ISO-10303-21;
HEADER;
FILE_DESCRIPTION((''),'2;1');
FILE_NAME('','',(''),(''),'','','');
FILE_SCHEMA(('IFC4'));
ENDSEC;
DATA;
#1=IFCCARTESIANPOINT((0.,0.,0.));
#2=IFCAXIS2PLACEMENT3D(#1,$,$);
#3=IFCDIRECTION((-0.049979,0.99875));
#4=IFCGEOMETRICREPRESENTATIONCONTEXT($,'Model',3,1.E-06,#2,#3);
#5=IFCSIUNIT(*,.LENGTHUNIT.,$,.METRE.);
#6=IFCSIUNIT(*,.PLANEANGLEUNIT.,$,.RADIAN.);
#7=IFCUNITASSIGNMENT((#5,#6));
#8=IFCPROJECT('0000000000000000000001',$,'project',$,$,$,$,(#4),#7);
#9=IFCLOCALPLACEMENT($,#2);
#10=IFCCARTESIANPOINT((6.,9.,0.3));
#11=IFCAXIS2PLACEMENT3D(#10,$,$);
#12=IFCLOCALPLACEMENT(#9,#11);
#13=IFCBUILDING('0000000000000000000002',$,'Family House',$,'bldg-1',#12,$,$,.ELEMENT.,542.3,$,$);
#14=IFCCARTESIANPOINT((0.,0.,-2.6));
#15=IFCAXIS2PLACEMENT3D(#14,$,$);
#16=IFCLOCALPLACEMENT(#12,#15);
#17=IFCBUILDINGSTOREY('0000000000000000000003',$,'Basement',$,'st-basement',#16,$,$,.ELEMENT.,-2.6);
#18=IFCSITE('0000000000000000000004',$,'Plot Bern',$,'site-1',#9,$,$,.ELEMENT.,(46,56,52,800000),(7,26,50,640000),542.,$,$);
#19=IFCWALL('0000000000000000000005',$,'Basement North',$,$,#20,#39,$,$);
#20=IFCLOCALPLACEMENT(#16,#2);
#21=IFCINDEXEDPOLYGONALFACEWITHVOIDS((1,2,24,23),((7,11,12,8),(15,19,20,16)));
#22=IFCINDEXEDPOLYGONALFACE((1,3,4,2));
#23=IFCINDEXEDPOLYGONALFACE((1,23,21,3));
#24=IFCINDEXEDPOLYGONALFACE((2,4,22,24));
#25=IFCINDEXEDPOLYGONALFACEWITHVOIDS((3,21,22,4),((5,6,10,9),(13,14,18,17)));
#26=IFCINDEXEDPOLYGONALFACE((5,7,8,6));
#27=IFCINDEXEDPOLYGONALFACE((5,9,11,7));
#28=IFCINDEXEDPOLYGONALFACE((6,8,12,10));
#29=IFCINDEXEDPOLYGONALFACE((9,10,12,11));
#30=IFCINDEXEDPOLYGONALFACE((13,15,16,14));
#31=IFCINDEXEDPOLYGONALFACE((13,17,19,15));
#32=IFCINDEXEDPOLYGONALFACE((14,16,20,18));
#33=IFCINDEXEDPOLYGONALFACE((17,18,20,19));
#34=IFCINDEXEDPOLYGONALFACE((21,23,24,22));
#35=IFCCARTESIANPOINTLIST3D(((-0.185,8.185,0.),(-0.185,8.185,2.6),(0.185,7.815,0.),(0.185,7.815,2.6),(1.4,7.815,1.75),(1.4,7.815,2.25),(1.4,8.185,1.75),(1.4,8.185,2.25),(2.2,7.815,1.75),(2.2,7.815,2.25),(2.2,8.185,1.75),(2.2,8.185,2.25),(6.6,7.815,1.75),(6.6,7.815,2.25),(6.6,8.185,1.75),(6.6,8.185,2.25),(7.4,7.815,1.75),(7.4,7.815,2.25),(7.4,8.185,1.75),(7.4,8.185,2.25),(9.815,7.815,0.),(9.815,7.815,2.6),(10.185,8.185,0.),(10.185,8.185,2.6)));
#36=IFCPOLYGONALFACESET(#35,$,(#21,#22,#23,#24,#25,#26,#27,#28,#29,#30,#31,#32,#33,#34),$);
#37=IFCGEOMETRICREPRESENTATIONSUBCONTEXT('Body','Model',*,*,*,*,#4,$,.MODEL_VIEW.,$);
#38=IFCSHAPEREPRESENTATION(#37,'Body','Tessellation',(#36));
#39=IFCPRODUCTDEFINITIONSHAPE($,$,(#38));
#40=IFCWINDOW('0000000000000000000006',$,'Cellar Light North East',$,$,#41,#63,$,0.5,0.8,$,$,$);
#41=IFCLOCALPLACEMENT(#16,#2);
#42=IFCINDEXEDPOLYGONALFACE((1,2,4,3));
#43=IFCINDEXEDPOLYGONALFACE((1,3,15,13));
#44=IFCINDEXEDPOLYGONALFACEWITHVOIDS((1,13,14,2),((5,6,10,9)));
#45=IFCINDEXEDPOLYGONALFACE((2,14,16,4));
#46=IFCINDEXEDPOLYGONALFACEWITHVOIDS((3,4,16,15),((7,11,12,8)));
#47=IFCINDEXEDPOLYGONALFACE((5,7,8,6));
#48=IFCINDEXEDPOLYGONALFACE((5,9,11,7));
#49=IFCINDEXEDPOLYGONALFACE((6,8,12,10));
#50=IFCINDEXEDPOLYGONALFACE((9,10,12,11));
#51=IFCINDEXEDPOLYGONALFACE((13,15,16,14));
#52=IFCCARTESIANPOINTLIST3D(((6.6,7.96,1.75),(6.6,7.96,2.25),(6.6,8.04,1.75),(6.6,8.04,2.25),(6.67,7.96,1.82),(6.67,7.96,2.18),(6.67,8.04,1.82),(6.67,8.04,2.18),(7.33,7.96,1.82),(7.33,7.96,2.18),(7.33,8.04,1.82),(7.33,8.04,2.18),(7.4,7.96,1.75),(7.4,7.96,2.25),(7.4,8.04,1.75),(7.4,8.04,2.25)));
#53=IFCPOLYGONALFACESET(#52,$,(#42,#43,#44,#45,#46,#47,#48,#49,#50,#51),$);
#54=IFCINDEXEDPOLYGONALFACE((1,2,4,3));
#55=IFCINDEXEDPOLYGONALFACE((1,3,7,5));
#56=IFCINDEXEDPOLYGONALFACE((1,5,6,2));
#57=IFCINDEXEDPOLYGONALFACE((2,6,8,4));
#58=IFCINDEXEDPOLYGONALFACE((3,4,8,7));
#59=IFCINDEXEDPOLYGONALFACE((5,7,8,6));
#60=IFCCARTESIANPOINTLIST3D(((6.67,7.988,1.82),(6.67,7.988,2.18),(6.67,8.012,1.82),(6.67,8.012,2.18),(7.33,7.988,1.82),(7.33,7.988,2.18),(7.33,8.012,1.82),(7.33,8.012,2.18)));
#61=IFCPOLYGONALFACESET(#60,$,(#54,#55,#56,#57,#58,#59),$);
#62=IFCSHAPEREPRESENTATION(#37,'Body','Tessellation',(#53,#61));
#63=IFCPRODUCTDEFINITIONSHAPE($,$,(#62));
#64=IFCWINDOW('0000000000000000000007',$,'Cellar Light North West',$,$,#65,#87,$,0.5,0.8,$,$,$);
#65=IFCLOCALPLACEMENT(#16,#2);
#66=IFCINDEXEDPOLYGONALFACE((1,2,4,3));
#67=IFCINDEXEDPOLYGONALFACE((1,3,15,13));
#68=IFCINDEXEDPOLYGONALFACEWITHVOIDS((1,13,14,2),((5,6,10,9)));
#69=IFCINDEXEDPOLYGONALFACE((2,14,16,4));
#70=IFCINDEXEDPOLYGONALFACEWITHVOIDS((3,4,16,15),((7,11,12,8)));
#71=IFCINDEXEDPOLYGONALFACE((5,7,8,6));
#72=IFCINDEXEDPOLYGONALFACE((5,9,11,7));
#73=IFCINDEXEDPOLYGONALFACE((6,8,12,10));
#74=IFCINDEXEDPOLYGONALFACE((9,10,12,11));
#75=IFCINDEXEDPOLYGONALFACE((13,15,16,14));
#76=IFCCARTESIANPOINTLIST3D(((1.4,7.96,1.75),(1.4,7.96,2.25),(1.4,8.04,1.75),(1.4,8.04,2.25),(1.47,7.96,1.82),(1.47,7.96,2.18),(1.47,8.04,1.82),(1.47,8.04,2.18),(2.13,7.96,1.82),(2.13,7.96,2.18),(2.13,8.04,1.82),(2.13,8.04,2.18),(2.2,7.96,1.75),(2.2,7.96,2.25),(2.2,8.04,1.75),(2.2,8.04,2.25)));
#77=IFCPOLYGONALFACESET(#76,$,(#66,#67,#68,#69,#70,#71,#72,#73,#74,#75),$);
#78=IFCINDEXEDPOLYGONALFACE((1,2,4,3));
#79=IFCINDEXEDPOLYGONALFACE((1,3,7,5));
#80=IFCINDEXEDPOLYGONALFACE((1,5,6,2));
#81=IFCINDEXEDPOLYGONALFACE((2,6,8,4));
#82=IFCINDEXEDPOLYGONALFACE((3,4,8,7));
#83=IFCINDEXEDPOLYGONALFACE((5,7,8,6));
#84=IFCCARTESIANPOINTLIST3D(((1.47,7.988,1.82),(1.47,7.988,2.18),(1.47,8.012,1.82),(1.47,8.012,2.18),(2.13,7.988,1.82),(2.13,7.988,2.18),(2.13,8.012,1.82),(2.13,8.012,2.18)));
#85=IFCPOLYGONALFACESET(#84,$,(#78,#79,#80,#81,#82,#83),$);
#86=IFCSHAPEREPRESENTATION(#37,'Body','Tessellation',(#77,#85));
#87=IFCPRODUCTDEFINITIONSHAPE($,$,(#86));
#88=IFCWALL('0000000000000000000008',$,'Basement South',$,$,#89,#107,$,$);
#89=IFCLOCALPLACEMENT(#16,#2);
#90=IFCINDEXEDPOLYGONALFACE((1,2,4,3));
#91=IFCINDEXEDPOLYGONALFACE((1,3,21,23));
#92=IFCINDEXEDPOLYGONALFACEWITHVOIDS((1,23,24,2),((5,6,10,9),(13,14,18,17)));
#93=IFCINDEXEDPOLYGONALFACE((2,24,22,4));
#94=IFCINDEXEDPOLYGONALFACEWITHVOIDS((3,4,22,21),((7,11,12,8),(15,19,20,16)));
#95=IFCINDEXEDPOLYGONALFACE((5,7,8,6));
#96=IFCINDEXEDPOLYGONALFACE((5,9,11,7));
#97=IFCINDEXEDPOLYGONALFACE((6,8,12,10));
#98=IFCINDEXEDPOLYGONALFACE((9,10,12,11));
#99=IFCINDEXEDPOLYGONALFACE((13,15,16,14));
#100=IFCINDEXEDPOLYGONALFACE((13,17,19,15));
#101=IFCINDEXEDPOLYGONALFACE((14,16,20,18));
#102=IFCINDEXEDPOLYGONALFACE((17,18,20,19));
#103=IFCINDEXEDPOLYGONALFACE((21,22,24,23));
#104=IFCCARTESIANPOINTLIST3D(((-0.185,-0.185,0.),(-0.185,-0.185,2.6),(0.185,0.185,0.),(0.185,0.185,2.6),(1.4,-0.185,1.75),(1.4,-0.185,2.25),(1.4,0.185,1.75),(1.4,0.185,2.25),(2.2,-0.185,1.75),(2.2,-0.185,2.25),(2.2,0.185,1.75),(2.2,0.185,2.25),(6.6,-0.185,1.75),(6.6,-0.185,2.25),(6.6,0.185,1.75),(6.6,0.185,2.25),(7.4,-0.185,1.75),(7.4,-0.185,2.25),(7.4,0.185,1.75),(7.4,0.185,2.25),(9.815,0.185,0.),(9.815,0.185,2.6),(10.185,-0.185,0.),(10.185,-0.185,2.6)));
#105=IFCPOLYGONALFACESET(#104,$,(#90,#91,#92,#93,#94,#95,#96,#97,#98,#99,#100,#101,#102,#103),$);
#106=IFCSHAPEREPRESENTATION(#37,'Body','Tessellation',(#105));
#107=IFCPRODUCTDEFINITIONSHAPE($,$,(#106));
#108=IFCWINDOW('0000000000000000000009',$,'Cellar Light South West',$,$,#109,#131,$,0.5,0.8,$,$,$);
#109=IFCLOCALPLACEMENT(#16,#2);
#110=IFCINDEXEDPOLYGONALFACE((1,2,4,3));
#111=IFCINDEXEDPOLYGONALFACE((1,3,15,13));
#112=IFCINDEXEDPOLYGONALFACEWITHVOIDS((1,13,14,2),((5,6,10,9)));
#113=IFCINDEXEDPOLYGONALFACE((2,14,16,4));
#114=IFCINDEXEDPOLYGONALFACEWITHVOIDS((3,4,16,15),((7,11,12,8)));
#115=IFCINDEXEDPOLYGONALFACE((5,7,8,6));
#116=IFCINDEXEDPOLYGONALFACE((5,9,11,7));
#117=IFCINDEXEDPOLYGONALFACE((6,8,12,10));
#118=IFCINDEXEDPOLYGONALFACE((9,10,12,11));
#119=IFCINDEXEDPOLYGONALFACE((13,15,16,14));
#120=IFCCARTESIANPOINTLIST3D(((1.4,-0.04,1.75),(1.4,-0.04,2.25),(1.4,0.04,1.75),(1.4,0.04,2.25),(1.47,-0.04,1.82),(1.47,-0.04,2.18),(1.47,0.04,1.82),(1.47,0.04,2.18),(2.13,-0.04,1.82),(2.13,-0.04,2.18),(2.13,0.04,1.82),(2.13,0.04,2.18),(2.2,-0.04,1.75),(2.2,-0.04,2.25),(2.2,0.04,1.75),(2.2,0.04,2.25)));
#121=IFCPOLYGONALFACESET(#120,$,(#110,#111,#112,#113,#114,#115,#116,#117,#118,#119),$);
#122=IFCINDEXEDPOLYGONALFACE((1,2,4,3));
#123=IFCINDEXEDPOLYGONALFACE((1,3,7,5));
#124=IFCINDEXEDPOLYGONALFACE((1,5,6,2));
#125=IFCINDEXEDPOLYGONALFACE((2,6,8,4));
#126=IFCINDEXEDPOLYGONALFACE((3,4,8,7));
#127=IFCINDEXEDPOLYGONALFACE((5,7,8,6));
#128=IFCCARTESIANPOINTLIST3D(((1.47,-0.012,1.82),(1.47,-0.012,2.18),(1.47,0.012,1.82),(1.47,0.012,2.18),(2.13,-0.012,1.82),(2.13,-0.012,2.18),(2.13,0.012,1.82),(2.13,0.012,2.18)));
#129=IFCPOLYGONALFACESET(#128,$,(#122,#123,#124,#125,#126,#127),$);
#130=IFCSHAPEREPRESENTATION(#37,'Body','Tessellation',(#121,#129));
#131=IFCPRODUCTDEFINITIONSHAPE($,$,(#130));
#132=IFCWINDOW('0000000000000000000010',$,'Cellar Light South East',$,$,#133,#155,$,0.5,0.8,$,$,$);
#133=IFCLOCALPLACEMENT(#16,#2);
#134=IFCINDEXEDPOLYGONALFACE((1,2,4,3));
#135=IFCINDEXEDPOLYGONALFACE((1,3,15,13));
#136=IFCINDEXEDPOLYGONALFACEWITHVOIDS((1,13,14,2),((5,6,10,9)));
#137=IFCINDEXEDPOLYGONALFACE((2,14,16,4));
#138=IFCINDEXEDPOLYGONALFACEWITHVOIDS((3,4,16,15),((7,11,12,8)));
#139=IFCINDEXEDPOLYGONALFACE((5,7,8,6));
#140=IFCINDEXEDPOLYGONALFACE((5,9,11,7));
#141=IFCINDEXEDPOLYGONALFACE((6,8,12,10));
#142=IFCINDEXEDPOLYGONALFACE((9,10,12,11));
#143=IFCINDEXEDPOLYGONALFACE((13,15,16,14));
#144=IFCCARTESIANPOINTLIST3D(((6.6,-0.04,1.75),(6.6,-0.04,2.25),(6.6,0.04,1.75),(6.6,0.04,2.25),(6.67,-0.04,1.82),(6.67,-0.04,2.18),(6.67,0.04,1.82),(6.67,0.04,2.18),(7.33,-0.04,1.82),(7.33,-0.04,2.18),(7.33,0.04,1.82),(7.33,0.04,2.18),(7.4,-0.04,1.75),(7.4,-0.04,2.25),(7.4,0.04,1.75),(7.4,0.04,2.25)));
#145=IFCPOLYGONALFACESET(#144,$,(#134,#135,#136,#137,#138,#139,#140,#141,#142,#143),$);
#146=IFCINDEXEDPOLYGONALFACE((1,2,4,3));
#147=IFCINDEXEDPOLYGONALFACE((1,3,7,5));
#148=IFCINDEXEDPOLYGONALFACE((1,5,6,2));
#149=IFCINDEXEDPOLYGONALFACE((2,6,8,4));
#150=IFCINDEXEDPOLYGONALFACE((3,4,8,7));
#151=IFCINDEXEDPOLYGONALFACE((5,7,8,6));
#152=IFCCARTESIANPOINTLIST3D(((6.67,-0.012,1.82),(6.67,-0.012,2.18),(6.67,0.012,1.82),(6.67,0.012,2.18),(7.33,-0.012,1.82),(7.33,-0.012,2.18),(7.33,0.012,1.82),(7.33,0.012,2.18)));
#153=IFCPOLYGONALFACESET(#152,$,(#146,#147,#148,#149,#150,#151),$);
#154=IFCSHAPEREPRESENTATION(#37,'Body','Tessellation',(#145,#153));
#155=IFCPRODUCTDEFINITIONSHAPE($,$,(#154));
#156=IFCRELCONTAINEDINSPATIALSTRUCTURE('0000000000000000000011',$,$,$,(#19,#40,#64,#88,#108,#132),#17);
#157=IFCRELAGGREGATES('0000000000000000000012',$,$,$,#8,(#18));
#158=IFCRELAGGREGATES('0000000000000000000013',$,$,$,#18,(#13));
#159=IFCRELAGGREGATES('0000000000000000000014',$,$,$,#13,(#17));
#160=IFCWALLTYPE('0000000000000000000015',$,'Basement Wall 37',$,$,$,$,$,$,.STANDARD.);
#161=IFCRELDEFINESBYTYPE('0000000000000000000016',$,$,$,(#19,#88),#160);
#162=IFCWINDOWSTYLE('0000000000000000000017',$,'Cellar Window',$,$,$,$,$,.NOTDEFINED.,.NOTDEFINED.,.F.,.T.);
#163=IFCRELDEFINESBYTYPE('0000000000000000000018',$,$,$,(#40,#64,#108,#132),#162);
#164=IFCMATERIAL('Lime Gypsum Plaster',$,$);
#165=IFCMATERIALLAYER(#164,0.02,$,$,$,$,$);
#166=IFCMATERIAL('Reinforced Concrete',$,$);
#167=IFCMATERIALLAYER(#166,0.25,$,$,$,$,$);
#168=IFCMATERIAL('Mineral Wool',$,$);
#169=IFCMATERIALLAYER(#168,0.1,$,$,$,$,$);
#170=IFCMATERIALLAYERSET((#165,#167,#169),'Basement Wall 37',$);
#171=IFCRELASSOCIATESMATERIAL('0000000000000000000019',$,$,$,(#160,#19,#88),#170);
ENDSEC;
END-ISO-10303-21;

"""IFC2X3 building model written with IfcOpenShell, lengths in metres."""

from ifc_helpers import new_model, si_unit, direction, frame, frame_2d, origin, origin_2d, place, context, subcontext, project, spatial, polyline, rectangle, outline, extrude, material, layer, layer_set, layer_usage, type_object, element, fill, save


model = new_model("IFC2X3")

# Units and contexts
model_context = context("Model", 3, precision=1e-06, world=origin(), true_north=direction((-0.049979, 0.99875)))
body_context = subcontext(model_context, "Body", "Model", "MODEL_VIEW")
ifc_project = project(units=[si_unit("LENGTHUNIT", "METRE"), si_unit("PLANEANGLEUNIT", "RADIAN")], contexts=[model_context])

# Site, building, storey
site_placement = place(None, origin())
site = spatial("IfcSite", under=ifc_project, at=site_placement, Name="Plot Bern", ObjectType="site-1", CompositionType="ELEMENT", RefLatitude=(46, 56, 52, 800000), RefLongitude=(7, 26, 50, 640000), RefElevation=542.0)
building_placement = place(site_placement, frame((6.0, 9.0, 0.3)))
building = spatial("IfcBuilding", under=site, at=building_placement, Name="Family House", ObjectType="bldg-1", CompositionType="ELEMENT", ElevationOfRefHeight=542.3)
storey_placement = place(building_placement, frame((0.0, 0.0, -2.6)))
storey = spatial("IfcBuildingStorey", under=building, at=storey_placement, Name="Basement", ObjectType="st-basement", CompositionType="ELEMENT", Elevation=-2.6)

# Shared definitions
ifc_material_1 = material(Name="Mineral Wool")
ifc_material_2 = material(Name="Reinforced Concrete")

# Shared definitions
ifc_material_3 = material(Name="Lime Gypsum Plaster")
ifc_layer_1 = layer(ifc_material_3, 0.02)
ifc_layer_2 = layer(ifc_material_2, 0.25)
ifc_layer_3 = layer(ifc_material_1, 0.1)
ifc_layer_set_1 = layer_set([ifc_layer_1, ifc_layer_2, ifc_layer_3], Name="Basement Wall 37")
wall_type_1 = type_object("IfcWallType", Name="Basement Wall 37", PredefinedType="STANDARD", material=ifc_layer_set_1)

# Walls, openings, windows
ifc_layer_usage_1 = layer_usage(ifc_layer_set_1, "AXIS2", "NEGATIVE", 0.185)
wall_1_placement = place(storey_placement, origin())
wall_1 = element("IfcWall", 1, at=wall_1_placement, inside=storey, type_object=wall_type_1, material=ifc_layer_usage_1, Name="Basement North", context=body_context, shape_type="SweptSolid", body=[
    extrude(outline(polyline([(10.185, 8.185), (-0.185, 8.185), (0.185, 7.815), (9.815, 7.815), (10.185, 8.185)])), origin(), (0.0, 0.0, 1.0), 2.6),
])
opening_1_placement = place(wall_1_placement, frame((7.0, 8.0, 1.75), z_axis=(0.0, 0.0, 1.0), x_axis=(-1.0, 0.0, 0.0)))
opening_1 = element("IfcOpeningElement", 2, at=opening_1_placement, cuts=wall_1, context=body_context, shape_type="SweptSolid", body=[
    extrude(rectangle(XDim=0.8, YDim=0.37, at=origin_2d()), origin(), (0.0, 0.0, 1.0), 0.5),
])
opening_2_placement = place(wall_1_placement, frame((1.8, 8.0, 1.75), z_axis=(0.0, 0.0, 1.0), x_axis=(-1.0, 0.0, 0.0)))
opening_2 = element("IfcOpeningElement", 3, at=opening_2_placement, cuts=wall_1, context=body_context, shape_type="SweptSolid", body=[
    extrude(rectangle(XDim=0.8, YDim=0.37, at=origin_2d()), origin(), (0.0, 0.0, 1.0), 0.5),
])
window_style = type_object("IfcWindowStyle", Name="Cellar Window", ConstructionType="NOTDEFINED", OperationType="NOTDEFINED", ParameterTakesPrecedence=False, Sizeable=True)
window_1_placement = place(opening_1_placement, frame((0.0, 0.0, 0.0), z_axis=(0.0, -1.0, 0.0), x_axis=(1.0, 0.0, 0.0)))
window_1 = element("IfcWindow", 4, at=window_1_placement, inside=storey, type_object=window_style, Name="Cellar Light North East", OverallHeight=0.5, OverallWidth=0.8, context=body_context, shape_type="SweptSolid", body=[
    extrude(outline(polyline([(-0.4, 0.0), (0.4, 0.0), (0.4, 0.5), (-0.4, 0.5), (-0.4, 0.0)]), holes=[polyline([(-0.33, 0.07), (0.33, 0.07), (0.33, 0.43), (-0.33, 0.43), (-0.33, 0.07)])]), frame((0.0, 0.0, -0.04)), (0.0, 0.0, 1.0), 0.08),
    extrude(rectangle(XDim=0.66, YDim=0.36, at=frame_2d((0.0, 0.25))), frame((0.0, 0.0, -0.012)), (0.0, 0.0, 1.0), 0.024),
])
fill(opening_1, window_1)
window_2_placement = place(opening_2_placement, frame((0.0, 0.0, 0.0), z_axis=(0.0, -1.0, 0.0), x_axis=(1.0, 0.0, 0.0)))
window_2 = element("IfcWindow", 5, at=window_2_placement, inside=storey, type_object=window_style, Name="Cellar Light North West", OverallHeight=0.5, OverallWidth=0.8, context=body_context, shape_type="SweptSolid", body=[
    extrude(outline(polyline([(-0.4, 0.0), (0.4, 0.0), (0.4, 0.5), (-0.4, 0.5), (-0.4, 0.0)]), holes=[polyline([(-0.33, 0.07), (0.33, 0.07), (0.33, 0.43), (-0.33, 0.43), (-0.33, 0.07)])]), frame((0.0, 0.0, -0.04)), (0.0, 0.0, 1.0), 0.08),
    extrude(rectangle(XDim=0.66, YDim=0.36, at=frame_2d((0.0, 0.25))), frame((0.0, 0.0, -0.012)), (0.0, 0.0, 1.0), 0.024),
])
fill(opening_2, window_2)
ifc_layer_usage_2 = layer_usage(ifc_layer_set_1, "AXIS2", "NEGATIVE", 0.185)
wall_2_placement = place(storey_placement, origin())
wall_2 = element("IfcWall", 6, at=wall_2_placement, inside=storey, type_object=wall_type_1, material=ifc_layer_usage_2, Name="Basement South", context=body_context, shape_type="SweptSolid", body=[
    extrude(outline(polyline([(-0.185, -0.185), (10.185, -0.185), (9.815, 0.185), (0.185, 0.185), (-0.185, -0.185)])), origin(), (0.0, 0.0, 1.0), 2.6),
])
opening_3_placement = place(wall_2_placement, frame((1.8, 0.0, 1.75), z_axis=(0.0, 0.0, 1.0), x_axis=(1.0, 0.0, 0.0)))
opening_3 = element("IfcOpeningElement", 7, at=opening_3_placement, cuts=wall_2, context=body_context, shape_type="SweptSolid", body=[
    extrude(rectangle(XDim=0.8, YDim=0.37, at=origin_2d()), origin(), (0.0, 0.0, 1.0), 0.5),
])
opening_4_placement = place(wall_2_placement, frame((7.0, 0.0, 1.75), z_axis=(0.0, 0.0, 1.0), x_axis=(1.0, 0.0, 0.0)))
opening_4 = element("IfcOpeningElement", 8, at=opening_4_placement, cuts=wall_2, context=body_context, shape_type="SweptSolid", body=[
    extrude(rectangle(XDim=0.8, YDim=0.37, at=origin_2d()), origin(), (0.0, 0.0, 1.0), 0.5),
])
window_3_placement = place(opening_3_placement, frame((0.0, 0.0, 0.0), z_axis=(0.0, -1.0, 0.0), x_axis=(1.0, 0.0, 0.0)))
window_3 = element("IfcWindow", 9, at=window_3_placement, inside=storey, type_object=window_style, Name="Cellar Light South West", OverallHeight=0.5, OverallWidth=0.8, context=body_context, shape_type="SweptSolid", body=[
    extrude(outline(polyline([(-0.4, 0.0), (0.4, 0.0), (0.4, 0.5), (-0.4, 0.5), (-0.4, 0.0)]), holes=[polyline([(-0.33, 0.07), (0.33, 0.07), (0.33, 0.43), (-0.33, 0.43), (-0.33, 0.07)])]), frame((0.0, 0.0, -0.04)), (0.0, 0.0, 1.0), 0.08),
    extrude(rectangle(XDim=0.66, YDim=0.36, at=frame_2d((0.0, 0.25))), frame((0.0, 0.0, -0.012)), (0.0, 0.0, 1.0), 0.024),
])
fill(opening_3, window_3)
window_4_placement = place(opening_4_placement, frame((0.0, 0.0, 0.0), z_axis=(0.0, -1.0, 0.0), x_axis=(1.0, 0.0, 0.0)))
window_4 = element("IfcWindow", 10, at=window_4_placement, inside=storey, type_object=window_style, Name="Cellar Light South East", OverallHeight=0.5, OverallWidth=0.8, context=body_context, shape_type="SweptSolid", body=[
    extrude(outline(polyline([(-0.4, 0.0), (0.4, 0.0), (0.4, 0.5), (-0.4, 0.5), (-0.4, 0.0)]), holes=[polyline([(-0.33, 0.07), (0.33, 0.07), (0.33, 0.43), (-0.33, 0.43), (-0.33, 0.07)])]), frame((0.0, 0.0, -0.04)), (0.0, 0.0, 1.0), 0.08),
    extrude(rectangle(XDim=0.66, YDim=0.36, at=frame_2d((0.0, 0.25))), frame((0.0, 0.0, -0.012)), (0.0, 0.0, 1.0), 0.024),
])
fill(opening_4, window_4)

save(model, "model.ifc")
